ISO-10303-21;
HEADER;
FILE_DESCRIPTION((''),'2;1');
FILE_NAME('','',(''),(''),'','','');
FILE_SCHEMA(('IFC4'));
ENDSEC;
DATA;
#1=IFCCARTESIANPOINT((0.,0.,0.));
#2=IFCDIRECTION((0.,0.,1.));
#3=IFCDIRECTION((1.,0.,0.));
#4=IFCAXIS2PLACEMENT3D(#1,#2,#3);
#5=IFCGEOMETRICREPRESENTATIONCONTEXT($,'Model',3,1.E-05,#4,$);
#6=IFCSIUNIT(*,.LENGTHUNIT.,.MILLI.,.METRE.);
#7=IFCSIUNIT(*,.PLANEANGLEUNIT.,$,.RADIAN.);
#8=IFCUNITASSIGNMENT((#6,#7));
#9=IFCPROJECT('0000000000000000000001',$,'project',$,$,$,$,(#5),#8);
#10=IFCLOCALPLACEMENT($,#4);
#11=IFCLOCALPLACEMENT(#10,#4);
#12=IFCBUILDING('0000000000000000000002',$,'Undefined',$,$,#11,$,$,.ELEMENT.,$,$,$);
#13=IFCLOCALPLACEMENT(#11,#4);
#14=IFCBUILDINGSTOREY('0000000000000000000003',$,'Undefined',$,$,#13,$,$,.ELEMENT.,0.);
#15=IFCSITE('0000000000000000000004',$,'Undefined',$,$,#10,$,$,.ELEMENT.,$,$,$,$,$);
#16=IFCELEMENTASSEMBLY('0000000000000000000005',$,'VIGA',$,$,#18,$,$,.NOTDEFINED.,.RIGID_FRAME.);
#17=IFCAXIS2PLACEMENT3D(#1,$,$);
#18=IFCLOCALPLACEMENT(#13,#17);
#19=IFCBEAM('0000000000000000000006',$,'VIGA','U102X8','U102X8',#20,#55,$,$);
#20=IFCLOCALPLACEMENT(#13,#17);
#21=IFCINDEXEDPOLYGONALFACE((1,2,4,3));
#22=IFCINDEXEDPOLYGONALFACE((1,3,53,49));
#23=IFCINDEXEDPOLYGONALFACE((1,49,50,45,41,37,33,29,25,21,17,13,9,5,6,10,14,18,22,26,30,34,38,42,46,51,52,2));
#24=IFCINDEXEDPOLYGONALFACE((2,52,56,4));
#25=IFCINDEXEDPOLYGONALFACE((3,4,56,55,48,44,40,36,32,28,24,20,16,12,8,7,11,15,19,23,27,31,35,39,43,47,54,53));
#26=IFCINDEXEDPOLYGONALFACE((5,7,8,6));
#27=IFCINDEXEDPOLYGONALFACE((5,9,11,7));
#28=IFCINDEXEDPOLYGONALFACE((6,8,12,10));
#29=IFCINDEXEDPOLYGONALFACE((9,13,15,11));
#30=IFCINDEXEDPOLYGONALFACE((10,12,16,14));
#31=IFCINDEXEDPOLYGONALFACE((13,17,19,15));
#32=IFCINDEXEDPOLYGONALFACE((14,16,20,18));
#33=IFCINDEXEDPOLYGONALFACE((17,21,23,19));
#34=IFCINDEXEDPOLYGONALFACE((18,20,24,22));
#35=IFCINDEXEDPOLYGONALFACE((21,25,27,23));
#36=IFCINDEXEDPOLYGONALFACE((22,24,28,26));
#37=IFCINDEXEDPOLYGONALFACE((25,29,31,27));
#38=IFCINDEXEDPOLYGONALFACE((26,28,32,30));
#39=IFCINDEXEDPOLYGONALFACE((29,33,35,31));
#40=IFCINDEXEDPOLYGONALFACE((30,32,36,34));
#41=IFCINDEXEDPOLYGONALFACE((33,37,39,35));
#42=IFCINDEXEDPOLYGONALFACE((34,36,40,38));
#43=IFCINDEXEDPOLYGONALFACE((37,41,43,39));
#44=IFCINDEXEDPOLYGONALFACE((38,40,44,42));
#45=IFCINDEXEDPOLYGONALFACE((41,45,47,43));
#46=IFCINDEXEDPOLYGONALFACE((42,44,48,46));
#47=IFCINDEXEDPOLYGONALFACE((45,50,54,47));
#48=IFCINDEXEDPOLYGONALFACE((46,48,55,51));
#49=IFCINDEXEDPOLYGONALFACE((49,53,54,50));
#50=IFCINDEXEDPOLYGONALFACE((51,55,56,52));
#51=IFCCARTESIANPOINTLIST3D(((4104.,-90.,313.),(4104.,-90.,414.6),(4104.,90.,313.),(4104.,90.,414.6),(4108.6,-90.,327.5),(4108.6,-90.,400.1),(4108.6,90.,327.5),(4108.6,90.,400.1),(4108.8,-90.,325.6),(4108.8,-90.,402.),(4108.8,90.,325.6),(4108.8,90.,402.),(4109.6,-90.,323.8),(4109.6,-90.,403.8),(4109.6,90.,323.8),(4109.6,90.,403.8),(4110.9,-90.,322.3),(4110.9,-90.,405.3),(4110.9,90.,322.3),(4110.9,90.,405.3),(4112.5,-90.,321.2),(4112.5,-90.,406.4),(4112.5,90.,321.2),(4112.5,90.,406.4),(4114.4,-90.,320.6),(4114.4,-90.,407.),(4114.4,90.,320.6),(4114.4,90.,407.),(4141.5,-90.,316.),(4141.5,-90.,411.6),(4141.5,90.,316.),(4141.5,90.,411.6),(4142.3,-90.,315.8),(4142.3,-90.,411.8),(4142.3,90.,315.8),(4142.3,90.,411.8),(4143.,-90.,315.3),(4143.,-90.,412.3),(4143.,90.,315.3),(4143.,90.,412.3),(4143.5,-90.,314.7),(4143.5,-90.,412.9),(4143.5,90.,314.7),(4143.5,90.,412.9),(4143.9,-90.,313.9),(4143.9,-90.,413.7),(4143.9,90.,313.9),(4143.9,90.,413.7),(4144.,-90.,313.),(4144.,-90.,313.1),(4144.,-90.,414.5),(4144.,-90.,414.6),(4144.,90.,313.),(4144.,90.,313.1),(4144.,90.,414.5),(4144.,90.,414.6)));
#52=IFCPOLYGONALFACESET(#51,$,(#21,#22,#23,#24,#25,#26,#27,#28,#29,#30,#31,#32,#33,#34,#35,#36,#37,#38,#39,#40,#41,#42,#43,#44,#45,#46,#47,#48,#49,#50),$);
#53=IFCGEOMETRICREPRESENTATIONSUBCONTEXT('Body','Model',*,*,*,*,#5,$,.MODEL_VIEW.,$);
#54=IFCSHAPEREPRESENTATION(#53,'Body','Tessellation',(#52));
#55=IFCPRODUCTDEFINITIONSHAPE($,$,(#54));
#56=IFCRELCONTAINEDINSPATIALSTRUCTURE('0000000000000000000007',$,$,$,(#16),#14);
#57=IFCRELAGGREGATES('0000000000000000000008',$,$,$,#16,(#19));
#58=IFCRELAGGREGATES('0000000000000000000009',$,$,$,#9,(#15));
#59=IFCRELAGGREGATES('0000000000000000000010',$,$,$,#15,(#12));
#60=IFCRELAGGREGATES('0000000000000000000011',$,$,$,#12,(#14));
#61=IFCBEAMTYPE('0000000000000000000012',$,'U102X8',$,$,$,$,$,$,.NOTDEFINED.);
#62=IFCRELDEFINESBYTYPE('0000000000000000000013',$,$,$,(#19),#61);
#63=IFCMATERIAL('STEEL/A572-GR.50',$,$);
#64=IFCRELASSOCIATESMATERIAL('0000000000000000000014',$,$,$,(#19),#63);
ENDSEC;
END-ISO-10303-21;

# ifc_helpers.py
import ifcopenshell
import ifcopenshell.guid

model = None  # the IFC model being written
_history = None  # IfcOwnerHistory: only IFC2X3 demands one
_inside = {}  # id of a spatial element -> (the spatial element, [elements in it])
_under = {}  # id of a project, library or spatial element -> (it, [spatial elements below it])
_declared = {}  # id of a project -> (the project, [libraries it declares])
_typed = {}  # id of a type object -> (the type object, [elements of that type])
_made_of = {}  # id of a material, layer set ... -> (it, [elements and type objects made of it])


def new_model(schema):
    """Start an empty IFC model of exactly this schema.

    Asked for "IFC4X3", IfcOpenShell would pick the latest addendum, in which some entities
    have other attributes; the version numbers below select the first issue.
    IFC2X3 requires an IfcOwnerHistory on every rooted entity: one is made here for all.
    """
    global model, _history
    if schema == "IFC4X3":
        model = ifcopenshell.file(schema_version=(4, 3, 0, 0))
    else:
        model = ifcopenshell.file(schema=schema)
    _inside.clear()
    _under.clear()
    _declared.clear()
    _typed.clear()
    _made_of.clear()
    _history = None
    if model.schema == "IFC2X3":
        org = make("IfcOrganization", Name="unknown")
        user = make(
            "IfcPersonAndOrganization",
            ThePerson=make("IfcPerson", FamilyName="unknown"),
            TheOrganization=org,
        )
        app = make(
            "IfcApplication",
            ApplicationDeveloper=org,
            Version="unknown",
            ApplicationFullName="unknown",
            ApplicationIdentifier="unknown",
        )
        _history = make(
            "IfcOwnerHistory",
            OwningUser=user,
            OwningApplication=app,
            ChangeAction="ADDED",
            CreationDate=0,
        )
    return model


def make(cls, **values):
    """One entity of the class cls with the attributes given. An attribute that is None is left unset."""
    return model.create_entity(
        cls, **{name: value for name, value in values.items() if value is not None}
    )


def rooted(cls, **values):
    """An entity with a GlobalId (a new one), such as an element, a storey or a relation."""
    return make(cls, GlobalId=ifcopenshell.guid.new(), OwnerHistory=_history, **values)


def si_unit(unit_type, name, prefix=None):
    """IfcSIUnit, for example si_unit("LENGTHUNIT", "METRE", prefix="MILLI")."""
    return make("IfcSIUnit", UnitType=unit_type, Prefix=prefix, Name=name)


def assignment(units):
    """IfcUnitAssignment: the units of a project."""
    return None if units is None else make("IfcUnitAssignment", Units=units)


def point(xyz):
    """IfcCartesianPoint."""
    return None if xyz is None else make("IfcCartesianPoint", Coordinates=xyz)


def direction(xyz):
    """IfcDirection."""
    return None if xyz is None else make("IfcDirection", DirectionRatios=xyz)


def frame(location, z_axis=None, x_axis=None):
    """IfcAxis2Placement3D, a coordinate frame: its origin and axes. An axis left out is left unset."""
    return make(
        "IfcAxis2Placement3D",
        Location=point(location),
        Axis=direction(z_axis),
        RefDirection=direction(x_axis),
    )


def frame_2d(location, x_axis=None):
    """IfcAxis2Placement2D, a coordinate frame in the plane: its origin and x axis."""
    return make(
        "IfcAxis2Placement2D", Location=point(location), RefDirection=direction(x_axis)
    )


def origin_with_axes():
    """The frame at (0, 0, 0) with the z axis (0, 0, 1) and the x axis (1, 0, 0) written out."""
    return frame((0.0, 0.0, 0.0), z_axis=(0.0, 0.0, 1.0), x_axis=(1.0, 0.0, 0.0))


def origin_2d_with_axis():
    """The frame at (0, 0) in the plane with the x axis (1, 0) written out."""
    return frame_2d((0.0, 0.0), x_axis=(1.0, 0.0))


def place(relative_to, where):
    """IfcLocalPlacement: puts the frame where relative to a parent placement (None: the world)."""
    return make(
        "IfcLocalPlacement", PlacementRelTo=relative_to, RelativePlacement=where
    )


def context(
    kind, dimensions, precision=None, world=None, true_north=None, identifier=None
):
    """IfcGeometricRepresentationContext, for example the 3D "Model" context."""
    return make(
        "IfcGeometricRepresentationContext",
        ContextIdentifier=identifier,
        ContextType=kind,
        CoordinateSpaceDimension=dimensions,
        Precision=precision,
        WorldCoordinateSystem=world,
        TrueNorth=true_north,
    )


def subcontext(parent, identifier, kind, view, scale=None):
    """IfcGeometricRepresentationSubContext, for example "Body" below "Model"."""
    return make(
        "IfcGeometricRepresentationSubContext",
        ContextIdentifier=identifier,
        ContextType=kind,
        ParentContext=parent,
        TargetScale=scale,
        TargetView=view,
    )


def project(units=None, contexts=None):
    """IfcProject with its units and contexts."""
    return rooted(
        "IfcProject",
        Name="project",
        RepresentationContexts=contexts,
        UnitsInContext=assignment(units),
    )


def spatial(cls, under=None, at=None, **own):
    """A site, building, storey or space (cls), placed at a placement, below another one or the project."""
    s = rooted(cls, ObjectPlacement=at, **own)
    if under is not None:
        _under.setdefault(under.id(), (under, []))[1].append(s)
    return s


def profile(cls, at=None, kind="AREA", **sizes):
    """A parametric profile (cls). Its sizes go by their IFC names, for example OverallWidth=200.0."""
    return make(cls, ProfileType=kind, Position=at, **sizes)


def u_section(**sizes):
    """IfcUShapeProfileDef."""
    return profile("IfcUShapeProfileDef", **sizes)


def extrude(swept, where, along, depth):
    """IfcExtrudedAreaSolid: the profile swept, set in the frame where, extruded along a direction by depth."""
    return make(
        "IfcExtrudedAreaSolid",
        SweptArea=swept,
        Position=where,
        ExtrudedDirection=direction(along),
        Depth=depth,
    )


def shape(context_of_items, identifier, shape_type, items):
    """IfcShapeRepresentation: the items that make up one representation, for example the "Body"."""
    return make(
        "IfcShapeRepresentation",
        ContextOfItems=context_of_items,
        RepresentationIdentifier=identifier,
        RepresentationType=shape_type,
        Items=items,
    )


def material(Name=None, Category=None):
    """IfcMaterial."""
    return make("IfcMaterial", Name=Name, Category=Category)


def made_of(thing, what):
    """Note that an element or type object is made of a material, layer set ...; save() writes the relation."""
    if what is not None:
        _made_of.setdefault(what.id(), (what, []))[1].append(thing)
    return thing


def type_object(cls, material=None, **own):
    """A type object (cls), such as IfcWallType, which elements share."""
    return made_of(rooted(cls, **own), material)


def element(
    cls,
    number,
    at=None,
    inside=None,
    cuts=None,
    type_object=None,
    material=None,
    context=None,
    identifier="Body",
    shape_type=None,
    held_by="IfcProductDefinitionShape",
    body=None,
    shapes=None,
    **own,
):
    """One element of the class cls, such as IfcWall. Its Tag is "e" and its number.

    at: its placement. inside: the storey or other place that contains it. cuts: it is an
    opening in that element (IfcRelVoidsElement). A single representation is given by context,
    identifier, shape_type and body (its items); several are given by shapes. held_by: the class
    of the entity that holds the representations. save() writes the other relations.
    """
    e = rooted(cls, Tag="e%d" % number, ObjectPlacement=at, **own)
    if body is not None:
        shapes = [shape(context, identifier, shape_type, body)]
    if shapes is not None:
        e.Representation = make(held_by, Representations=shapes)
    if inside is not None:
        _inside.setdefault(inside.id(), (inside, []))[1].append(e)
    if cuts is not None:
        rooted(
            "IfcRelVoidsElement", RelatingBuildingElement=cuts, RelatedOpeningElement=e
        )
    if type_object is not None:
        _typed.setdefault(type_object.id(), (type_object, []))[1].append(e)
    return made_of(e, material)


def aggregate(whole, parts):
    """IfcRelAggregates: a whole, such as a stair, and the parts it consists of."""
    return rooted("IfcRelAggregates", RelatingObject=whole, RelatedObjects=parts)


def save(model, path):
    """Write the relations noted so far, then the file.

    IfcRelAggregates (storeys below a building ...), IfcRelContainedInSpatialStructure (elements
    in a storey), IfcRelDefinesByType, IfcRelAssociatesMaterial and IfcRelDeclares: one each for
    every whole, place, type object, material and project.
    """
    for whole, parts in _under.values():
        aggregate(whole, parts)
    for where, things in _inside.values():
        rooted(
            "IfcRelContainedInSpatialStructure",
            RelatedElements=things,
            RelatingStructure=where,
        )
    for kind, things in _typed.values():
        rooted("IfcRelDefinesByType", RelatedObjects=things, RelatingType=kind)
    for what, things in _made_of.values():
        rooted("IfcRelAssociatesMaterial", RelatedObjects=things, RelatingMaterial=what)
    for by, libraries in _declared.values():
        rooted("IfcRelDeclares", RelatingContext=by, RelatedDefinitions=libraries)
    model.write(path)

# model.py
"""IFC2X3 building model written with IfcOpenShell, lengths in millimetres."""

from ifc_helpers import new_model, si_unit, frame, origin_with_axes, origin_2d_with_axis, place, context, subcontext, project, spatial, u_section, extrude, material, type_object, element, aggregate, save


model = new_model("IFC2X3")

# Units and contexts
model_context = context("Model", 3, precision=1e-05, world=origin_with_axes())
body_context = subcontext(model_context, "Body", "Model", "MODEL_VIEW")
ifc_project = project(units=[si_unit("LENGTHUNIT", "METRE", prefix="MILLI"), si_unit("PLANEANGLEUNIT", "RADIAN")], contexts=[model_context])

# Site, building, storey
site_placement = place(None, origin_with_axes())
site = spatial("IfcSite", under=ifc_project, at=site_placement, Name="Undefined", CompositionType="ELEMENT")
building_placement = place(site_placement, origin_with_axes())
building = spatial("IfcBuilding", under=site, at=building_placement, Name="Undefined", CompositionType="ELEMENT")
storey_placement = place(building_placement, origin_with_axes())
storey = spatial("IfcBuildingStorey", under=building, at=storey_placement, Name="Undefined", CompositionType="ELEMENT", Elevation=0.0)

# Element assembly, beam
ifc_material = material(Name="STEEL/A572-GR.50")
beam_type = type_object("IfcBeamType", Name="U102X8", PredefinedType="NOTDEFINED")
assembly_1_placement = place(storey_placement, origin_with_axes())
assembly_1 = element("IfcElementAssembly", 1, at=assembly_1_placement, inside=storey, Name="VIGA", AssemblyPlace="NOTDEFINED", PredefinedType="RIGID_FRAME")
beam_1_placement = place(assembly_1_placement, frame((4124.0, -90.0, 363.8), z_axis=(0.0, 0.0, 1.0), x_axis=(0.0, 1.0, 0.0)))
beam_1 = element("IfcBeam", 2, at=beam_1_placement, type_object=beam_type, material=ifc_material, Name="VIGA", Description="U102X8", ObjectType="U102X8", context=body_context, shape_type="SweptSolid", body=[
    extrude(u_section(Depth=101.6, FlangeWidth=40.0, WebThickness=4.6, FlangeThickness=6.0, FilletRadius=7.0, EdgeRadius=3.0, FlangeSlope=0.16839, at=origin_2d_with_axis()), frame((180.0, 0.0, 0.0), z_axis=(-1.0, 0.0, 0.0), x_axis=(0.0, -1.0, 0.0)), (0.0, 0.0, 1.0), 180.0),
])
aggregate(assembly_1, [beam_1])

save(model, "model.ifc")
